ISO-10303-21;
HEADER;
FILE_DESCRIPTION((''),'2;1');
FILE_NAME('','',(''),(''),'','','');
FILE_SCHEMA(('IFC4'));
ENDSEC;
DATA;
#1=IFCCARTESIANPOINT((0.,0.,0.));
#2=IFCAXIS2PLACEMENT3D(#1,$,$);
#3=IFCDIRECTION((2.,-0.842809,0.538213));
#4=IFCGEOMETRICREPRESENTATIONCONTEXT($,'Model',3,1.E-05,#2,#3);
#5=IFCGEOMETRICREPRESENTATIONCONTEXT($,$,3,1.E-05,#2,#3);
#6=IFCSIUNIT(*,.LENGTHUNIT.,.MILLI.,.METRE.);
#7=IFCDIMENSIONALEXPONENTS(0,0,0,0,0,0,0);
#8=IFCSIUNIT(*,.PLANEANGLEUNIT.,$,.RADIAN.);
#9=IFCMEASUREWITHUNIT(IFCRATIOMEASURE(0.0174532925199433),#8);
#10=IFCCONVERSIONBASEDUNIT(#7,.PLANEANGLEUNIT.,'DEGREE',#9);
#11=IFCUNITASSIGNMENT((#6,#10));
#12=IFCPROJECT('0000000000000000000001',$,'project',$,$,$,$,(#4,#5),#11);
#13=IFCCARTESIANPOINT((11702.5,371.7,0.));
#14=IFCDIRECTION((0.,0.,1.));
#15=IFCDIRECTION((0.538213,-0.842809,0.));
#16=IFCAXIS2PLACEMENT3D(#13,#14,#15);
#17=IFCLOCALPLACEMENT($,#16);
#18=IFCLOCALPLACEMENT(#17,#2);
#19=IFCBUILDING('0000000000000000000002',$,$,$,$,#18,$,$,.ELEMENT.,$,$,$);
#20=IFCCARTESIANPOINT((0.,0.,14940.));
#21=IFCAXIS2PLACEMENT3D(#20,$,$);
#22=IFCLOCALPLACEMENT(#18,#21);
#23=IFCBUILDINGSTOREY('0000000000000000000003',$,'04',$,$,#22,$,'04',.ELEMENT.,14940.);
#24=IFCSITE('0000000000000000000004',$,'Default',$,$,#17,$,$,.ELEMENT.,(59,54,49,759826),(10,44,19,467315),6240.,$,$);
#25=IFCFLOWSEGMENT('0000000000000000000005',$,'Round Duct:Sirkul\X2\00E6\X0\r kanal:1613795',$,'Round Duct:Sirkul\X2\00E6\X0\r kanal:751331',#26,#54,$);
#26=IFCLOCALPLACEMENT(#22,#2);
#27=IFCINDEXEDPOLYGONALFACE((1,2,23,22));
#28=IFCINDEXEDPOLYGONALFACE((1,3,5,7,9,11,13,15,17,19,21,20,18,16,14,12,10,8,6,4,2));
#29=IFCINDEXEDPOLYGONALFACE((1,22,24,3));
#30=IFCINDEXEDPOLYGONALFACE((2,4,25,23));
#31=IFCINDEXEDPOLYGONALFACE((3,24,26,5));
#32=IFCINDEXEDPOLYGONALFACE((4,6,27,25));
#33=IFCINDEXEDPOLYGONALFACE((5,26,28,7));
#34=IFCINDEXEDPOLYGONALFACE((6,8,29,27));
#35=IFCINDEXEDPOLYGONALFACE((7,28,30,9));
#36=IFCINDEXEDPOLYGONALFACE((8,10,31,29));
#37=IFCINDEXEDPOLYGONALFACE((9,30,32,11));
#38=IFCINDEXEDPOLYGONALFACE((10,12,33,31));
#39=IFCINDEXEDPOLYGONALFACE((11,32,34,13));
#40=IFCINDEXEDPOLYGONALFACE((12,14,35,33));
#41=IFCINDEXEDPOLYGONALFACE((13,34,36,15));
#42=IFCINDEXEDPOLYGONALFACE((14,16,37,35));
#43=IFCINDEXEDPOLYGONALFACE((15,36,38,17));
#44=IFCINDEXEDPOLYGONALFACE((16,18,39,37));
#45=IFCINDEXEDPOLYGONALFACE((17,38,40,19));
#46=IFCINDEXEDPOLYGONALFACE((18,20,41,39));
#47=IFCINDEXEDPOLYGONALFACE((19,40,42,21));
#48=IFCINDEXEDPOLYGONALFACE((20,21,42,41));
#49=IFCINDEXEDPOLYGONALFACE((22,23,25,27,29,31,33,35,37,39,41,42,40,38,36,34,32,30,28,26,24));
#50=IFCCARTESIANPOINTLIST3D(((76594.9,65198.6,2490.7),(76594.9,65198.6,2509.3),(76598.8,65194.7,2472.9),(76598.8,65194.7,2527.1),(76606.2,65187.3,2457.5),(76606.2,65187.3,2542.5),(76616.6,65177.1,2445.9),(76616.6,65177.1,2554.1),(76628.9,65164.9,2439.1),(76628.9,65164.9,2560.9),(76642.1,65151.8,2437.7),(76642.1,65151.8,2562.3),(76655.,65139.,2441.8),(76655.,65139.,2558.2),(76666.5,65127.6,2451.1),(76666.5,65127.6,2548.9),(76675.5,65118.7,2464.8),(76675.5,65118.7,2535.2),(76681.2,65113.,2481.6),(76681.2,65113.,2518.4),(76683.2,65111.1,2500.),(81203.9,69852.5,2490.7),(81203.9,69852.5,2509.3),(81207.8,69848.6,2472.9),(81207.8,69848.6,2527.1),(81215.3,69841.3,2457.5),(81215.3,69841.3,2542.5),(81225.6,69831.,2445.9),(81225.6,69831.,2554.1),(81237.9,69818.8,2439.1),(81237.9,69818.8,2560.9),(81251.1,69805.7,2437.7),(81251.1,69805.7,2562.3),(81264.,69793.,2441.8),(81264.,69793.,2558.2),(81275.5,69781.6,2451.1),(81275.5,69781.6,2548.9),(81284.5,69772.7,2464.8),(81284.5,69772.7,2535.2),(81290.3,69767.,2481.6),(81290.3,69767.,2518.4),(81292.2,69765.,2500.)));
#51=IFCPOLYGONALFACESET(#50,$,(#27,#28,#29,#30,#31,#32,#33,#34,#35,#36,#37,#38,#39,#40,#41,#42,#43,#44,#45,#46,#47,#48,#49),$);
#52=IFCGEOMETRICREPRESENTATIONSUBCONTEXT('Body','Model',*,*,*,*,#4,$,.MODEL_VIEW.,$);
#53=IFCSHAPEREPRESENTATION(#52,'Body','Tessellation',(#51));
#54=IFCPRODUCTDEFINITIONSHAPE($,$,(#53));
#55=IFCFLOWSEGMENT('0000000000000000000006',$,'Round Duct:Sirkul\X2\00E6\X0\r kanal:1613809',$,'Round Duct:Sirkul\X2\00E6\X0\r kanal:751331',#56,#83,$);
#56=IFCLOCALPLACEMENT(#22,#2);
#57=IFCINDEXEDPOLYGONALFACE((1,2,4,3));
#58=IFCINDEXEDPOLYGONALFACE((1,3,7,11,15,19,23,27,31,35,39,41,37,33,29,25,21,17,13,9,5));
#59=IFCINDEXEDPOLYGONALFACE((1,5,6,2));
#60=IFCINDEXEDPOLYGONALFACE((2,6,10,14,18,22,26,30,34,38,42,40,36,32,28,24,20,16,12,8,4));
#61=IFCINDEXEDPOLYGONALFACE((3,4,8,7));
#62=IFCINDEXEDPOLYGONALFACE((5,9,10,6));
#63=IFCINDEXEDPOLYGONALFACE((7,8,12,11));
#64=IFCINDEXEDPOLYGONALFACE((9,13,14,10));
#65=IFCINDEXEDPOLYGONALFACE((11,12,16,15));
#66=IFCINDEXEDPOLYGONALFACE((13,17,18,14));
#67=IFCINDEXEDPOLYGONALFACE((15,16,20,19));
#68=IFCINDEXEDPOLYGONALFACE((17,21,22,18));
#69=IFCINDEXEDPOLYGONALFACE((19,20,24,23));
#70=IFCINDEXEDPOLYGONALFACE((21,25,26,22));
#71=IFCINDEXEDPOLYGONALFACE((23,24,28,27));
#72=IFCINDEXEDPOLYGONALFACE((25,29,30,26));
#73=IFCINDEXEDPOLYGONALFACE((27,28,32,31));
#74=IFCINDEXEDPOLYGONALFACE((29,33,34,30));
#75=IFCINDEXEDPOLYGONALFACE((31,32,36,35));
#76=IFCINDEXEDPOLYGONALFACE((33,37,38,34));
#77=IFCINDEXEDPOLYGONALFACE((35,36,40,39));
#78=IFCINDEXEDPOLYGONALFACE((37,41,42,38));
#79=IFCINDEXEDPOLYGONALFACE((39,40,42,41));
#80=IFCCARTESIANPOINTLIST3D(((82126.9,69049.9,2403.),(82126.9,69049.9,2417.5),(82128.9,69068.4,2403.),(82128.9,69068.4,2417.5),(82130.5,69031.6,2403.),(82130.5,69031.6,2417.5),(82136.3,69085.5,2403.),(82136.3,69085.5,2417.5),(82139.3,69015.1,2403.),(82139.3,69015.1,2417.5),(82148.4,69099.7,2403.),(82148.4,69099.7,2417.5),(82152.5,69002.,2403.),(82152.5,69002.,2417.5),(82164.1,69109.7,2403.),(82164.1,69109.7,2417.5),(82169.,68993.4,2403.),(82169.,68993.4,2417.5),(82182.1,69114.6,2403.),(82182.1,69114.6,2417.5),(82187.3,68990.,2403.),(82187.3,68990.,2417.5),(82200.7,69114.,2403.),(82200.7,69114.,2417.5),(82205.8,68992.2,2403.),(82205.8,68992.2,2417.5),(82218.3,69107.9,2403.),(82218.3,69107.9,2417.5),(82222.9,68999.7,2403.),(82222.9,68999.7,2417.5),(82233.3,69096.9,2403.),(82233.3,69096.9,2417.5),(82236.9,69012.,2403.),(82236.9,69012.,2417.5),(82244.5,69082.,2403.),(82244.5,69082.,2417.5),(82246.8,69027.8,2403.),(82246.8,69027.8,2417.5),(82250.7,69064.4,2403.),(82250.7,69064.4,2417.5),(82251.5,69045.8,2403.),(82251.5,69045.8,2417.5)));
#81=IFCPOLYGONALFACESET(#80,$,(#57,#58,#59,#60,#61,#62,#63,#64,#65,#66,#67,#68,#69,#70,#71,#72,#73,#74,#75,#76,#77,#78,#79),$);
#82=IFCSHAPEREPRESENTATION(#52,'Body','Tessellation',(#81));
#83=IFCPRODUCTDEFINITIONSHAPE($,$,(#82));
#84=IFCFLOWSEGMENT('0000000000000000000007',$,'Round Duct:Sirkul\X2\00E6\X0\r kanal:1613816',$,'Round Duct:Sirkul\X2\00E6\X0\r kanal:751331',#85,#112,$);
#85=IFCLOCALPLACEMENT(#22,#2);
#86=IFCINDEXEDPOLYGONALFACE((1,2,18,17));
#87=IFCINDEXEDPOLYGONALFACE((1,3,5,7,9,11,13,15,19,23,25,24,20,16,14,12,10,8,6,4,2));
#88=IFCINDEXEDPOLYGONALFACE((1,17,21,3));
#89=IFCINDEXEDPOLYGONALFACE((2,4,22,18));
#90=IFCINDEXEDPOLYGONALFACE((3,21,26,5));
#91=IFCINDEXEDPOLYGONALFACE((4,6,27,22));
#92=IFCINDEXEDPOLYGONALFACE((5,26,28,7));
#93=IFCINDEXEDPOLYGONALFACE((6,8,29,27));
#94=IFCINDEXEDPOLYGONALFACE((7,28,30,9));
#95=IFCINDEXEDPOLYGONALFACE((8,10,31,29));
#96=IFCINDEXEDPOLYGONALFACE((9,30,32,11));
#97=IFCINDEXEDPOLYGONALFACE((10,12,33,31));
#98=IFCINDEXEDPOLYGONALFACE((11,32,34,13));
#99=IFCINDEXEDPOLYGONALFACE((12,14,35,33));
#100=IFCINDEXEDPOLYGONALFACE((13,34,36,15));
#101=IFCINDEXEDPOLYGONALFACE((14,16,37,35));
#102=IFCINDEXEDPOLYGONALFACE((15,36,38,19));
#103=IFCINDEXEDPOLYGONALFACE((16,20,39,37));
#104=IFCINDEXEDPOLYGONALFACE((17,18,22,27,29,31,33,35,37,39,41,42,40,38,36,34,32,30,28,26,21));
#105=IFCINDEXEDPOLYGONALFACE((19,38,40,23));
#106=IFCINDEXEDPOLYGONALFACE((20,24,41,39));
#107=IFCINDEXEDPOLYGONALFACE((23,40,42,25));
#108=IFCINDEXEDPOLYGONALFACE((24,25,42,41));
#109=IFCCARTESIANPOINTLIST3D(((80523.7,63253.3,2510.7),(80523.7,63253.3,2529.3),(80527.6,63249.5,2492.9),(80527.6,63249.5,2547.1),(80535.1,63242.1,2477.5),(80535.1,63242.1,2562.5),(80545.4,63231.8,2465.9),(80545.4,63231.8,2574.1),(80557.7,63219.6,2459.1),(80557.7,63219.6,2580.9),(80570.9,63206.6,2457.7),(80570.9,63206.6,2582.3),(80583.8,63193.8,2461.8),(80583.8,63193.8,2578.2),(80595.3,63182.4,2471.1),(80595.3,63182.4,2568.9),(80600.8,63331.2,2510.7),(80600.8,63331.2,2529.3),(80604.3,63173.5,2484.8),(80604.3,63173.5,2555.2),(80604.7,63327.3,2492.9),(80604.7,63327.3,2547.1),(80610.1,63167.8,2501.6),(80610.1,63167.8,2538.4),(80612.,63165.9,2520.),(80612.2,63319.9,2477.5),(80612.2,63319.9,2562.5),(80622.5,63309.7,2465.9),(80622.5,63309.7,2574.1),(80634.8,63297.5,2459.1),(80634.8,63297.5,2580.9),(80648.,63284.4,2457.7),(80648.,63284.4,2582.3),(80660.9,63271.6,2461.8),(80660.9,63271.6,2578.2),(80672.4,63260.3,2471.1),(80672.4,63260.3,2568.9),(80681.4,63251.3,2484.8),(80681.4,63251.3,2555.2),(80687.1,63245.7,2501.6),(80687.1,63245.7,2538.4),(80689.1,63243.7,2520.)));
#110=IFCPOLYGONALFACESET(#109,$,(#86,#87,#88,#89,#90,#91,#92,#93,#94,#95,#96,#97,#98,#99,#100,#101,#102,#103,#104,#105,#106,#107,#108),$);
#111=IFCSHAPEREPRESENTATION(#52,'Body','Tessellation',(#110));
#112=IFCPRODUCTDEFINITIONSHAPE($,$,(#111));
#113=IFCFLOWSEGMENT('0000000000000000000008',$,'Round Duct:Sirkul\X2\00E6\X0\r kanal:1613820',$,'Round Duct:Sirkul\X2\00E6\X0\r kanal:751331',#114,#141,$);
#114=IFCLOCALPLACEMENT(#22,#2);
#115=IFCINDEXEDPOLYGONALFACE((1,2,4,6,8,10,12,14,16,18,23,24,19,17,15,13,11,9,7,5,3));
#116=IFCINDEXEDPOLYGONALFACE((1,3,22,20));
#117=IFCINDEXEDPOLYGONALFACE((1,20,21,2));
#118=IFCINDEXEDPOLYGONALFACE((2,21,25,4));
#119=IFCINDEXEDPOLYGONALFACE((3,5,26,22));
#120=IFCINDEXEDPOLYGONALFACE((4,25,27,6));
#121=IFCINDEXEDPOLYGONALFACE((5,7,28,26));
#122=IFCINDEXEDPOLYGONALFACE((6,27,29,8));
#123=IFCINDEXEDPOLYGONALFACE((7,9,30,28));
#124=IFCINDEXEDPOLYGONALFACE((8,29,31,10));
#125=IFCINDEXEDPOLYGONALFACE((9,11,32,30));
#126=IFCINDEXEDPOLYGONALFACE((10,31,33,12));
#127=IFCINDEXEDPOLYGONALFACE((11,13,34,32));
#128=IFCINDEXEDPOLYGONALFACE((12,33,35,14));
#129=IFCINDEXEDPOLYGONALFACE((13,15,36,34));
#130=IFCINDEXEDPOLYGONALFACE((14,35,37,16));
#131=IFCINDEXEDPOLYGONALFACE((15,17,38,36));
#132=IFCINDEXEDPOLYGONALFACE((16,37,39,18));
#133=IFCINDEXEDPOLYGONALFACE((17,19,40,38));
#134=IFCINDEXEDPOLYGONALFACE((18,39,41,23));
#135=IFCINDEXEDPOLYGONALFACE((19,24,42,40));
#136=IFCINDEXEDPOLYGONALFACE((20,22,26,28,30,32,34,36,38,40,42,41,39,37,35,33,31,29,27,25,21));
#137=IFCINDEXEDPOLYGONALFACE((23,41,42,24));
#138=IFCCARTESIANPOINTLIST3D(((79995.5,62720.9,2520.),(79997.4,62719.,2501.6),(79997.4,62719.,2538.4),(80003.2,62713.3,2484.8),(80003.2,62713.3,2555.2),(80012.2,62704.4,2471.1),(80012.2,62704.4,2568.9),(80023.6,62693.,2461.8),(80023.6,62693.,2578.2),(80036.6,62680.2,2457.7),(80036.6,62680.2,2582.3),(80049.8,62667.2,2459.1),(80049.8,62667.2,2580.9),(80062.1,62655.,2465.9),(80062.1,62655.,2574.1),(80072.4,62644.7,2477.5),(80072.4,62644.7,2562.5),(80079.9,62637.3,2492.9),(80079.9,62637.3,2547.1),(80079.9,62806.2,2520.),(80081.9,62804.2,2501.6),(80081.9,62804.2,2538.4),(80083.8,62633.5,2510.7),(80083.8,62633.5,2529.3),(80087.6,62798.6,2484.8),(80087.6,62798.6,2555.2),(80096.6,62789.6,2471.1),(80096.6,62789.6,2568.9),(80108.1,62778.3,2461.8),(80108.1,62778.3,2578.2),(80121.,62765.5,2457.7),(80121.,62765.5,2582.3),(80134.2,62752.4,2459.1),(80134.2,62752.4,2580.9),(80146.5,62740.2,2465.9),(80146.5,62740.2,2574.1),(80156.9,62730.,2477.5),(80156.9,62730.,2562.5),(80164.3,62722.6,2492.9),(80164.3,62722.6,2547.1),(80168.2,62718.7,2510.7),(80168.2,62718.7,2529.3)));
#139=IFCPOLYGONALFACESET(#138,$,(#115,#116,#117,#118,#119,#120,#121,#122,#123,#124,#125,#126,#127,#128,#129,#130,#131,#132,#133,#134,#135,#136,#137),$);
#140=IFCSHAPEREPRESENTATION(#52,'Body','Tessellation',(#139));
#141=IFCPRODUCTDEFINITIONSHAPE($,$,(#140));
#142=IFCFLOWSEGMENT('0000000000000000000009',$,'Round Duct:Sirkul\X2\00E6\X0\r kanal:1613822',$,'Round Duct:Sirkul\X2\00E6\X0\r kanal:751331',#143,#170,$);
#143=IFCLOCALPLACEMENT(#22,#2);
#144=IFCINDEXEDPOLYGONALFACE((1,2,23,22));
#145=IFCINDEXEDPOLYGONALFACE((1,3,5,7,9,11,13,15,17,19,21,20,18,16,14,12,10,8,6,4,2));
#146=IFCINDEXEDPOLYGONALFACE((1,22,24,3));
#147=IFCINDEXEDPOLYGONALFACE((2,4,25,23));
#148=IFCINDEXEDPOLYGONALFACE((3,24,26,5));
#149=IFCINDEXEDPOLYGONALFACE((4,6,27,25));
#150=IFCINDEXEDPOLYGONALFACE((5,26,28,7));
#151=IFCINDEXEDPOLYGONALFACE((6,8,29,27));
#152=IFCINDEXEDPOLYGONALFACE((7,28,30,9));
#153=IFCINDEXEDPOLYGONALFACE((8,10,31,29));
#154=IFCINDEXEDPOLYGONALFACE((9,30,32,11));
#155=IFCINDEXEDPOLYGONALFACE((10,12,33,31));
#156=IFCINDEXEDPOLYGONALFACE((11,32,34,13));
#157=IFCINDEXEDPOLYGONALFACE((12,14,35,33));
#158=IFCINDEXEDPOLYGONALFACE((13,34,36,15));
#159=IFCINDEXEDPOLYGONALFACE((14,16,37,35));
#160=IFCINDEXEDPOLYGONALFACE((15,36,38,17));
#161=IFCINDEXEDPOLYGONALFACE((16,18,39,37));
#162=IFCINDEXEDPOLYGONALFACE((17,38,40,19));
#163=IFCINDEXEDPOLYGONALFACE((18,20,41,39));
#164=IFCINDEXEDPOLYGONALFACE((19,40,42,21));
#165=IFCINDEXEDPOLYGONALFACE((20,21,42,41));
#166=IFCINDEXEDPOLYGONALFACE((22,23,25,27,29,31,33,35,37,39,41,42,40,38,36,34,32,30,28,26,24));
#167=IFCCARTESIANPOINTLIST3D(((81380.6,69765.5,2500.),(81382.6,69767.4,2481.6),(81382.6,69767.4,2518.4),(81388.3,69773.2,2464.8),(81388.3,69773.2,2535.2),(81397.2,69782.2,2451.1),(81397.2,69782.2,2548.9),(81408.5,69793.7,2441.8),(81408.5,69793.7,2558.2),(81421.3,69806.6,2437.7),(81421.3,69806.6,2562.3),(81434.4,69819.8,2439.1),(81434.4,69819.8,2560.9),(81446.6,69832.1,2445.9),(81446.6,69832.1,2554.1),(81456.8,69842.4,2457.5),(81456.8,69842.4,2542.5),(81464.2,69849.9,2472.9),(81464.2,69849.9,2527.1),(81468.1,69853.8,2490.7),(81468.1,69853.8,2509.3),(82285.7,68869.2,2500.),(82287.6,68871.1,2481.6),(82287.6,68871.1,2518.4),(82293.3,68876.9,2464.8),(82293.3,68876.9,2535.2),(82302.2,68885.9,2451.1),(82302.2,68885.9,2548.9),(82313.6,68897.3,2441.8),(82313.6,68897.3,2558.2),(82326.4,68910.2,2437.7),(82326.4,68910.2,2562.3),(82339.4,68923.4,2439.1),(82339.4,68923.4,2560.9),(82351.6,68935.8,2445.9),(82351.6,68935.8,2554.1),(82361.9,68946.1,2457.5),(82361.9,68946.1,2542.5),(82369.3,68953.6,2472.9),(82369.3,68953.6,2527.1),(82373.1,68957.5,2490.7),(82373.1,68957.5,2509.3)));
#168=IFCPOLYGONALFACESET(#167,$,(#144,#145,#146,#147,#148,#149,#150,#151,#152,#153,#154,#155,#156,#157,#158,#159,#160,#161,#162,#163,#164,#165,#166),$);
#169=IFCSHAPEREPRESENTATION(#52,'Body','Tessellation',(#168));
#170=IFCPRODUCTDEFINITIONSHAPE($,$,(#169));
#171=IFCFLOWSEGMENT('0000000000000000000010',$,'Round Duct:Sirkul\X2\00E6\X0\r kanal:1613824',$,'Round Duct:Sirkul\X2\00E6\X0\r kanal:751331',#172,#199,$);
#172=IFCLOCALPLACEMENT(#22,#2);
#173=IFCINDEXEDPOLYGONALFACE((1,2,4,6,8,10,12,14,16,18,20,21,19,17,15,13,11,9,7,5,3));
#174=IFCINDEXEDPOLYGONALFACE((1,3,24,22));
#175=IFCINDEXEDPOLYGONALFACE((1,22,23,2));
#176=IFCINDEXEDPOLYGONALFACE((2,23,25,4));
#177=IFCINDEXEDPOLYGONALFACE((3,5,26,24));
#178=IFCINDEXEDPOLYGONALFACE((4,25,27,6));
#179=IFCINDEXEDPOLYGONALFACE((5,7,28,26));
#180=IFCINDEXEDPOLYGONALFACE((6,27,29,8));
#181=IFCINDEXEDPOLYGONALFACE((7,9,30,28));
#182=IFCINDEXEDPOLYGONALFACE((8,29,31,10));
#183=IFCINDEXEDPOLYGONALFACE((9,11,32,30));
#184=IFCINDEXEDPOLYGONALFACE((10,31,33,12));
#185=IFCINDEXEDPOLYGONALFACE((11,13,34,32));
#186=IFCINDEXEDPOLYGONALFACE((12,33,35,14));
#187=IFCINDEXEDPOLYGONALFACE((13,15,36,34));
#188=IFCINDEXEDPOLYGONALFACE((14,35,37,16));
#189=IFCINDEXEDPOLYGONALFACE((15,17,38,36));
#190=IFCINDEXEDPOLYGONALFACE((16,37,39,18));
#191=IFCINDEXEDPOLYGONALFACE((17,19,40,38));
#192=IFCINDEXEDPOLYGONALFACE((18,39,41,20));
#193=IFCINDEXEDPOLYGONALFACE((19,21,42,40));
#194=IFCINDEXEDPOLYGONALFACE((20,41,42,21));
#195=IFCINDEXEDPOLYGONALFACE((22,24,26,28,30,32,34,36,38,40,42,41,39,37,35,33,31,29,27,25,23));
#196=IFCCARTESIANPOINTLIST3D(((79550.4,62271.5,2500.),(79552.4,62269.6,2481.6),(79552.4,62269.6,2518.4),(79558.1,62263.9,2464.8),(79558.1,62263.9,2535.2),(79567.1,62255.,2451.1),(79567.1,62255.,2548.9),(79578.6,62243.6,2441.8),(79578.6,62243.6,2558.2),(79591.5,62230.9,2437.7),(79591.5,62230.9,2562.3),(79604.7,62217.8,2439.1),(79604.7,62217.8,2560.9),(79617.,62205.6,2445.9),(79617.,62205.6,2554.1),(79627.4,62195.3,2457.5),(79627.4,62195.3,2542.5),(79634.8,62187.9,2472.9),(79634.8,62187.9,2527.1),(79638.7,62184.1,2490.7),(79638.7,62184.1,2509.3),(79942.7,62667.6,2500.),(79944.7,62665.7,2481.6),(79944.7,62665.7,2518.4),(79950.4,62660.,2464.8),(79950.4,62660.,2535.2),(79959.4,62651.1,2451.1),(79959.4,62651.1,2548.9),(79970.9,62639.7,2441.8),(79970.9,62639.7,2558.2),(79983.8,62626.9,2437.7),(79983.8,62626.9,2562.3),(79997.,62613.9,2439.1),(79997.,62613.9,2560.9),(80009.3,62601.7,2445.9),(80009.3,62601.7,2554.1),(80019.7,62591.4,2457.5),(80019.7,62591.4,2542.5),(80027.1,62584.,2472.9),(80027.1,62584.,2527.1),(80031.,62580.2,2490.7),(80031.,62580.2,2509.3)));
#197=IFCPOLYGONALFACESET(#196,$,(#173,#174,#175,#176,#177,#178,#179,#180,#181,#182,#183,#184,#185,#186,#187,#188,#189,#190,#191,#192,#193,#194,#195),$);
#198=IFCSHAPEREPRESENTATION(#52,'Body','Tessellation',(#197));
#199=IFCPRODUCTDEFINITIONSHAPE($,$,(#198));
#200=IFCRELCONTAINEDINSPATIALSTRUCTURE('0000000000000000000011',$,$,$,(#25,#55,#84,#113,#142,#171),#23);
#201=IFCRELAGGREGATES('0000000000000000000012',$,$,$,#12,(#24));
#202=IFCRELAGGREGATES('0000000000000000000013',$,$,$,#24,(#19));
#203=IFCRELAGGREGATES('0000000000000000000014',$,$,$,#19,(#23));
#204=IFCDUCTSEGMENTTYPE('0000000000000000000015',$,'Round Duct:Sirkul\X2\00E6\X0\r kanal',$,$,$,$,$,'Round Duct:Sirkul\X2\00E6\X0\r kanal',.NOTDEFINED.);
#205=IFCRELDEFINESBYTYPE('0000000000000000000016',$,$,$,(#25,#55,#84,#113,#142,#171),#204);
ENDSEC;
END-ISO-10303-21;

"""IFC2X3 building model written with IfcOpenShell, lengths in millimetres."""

from ifc_helpers import new_model, entity, si_unit, converted_unit, direction, frame, frame_2d, origin, origin_2d_with_axis, place, context, subcontext, project, spatial, circle, extrude, type_object, element, save


model = new_model("IFC2X3")

# Units and contexts
model_context = context("Model", 3, precision=1e-05, world=origin(), true_north=direction((2.0, -0.842809, 0.538213)))
context_of_model = context(None, 3, precision=1e-05, world=origin(), true_north=direction((2.0, -0.842809, 0.538213)))
body_context = subcontext(model_context, "Body", "Model", "MODEL_VIEW")
ifc_project = project(units=[si_unit("LENGTHUNIT", "METRE", prefix="MILLI"), converted_unit("PLANEANGLEUNIT", "DEGREE", entity("IfcRatioMeasure", 0.0174532925199433), si_unit("PLANEANGLEUNIT", "RADIAN"), dimensions=[0, 0, 0, 0, 0, 0, 0])], contexts=[model_context, context_of_model])

# Site, building, storey
site_placement = place(None, frame((11702.5, 371.7, 0.0), z_axis=(0.0, 0.0, 1.0), x_axis=(0.538213, -0.842809, 0.0)))
site = spatial("IfcSite", under=ifc_project, at=site_placement, Name="Default", CompositionType="ELEMENT", RefLatitude=(59, 54, 49, 759826), RefLongitude=(10, 44, 19, 467315), RefElevation=6240.0)
building_placement = place(site_placement, origin())
building = spatial("IfcBuilding", under=site, at=building_placement, CompositionType="ELEMENT")
storey_placement = place(building_placement, frame((0.0, 0.0, 14940.0)))
storey = spatial("IfcBuildingStorey", under=building, at=storey_placement, Name="04", LongName="04", CompositionType="ELEMENT", Elevation=14940.0)

# Flow segments
duct_segment_type = type_object("IfcDuctSegmentType", Name="Round Duct:Sirkulær kanal", ElementType="Round Duct:Sirkulær kanal", PredefinedType="NOTDEFINED")
flow_segment_1_placement = place(storey_placement, origin())
element("IfcFlowSegment", 1, at=flow_segment_1_placement, inside=storey, type_object=duct_segment_type, Name="Round Duct:Sirkulær kanal:1613795", ObjectType="Round Duct:Sirkulær kanal:751331", context=body_context, shape_type="SweptSolid", body=[
    extrude(circle(Radius=62.5, at=origin_2d_with_axis()), frame((76638.8, 65155.1, 2500.0), z_axis=(0.703669, 0.710528, 0.0), x_axis=(0.710528, -0.703669, 0.0)), (0.0, 0.0, 1.0), 6550.0),
])
flow_segment_2_placement = place(storey_placement, origin())
element("IfcFlowSegment", 2, at=flow_segment_2_placement, inside=storey, type_object=duct_segment_type, Name="Round Duct:Sirkulær kanal:1613809", ObjectType="Round Duct:Sirkulær kanal:751331", context=body_context, shape_type="SweptSolid", body=[
    extrude(circle(Radius=62.5, at=frame_2d((0.0, 0.0), x_axis=(1.0, 0.0))), frame((82189.4, 69052.5, 2403.0), z_axis=(0.0, 0.0, 1.0), x_axis=(0.703669, 0.710528, 0.0)), (0.0, 0.0, 1.0), 14.5),
])
flow_segment_3_placement = place(storey_placement, origin())
element("IfcFlowSegment", 3, at=flow_segment_3_placement, inside=storey, type_object=duct_segment_type, Name="Round Duct:Sirkulær kanal:1613816", ObjectType="Round Duct:Sirkulær kanal:751331", context=body_context, shape_type="SweptSolid", body=[
    extrude(circle(Radius=62.5, at=frame_2d((0.0, 0.0), x_axis=(1.0, 0.0))), frame((80567.6, 63209.8, 2520.0), z_axis=(0.703669, 0.710528, 0.0), x_axis=(0.710528, -0.703669, 0.0)), (0.0, 0.0, 1.0), 109.6),
])
flow_segment_4_placement = place(storey_placement, origin())
element("IfcFlowSegment", 4, at=flow_segment_4_placement, inside=storey, type_object=duct_segment_type, Name="Round Duct:Sirkulær kanal:1613820", ObjectType="Round Duct:Sirkulær kanal:751331", context=body_context, shape_type="SweptSolid", body=[
    extrude(circle(Radius=62.5, at=origin_2d_with_axis()), frame((80039.9, 62677.0, 2520.0), z_axis=(0.703669, 0.710528, 0.0), x_axis=(-0.710528, 0.703669, 0.0)), (0.0, 0.0, 1.0), 120.0),
])
flow_segment_5_placement = place(storey_placement, origin())
element("IfcFlowSegment", 5, at=flow_segment_5_placement, inside=storey, type_object=duct_segment_type, Name="Round Duct:Sirkulær kanal:1613822", ObjectType="Round Duct:Sirkulær kanal:751331", context=body_context, shape_type="SweptSolid", body=[
    extrude(circle(Radius=62.5, at=origin_2d_with_axis()), frame((81424.6, 69809.9, 2500.0), z_axis=(0.710528, -0.703669, 0.0), x_axis=(-0.703669, -0.710528, 0.0)), (0.0, 0.0, 1.0), 1273.8),
])
flow_segment_6_placement = place(storey_placement, origin())
element("IfcFlowSegment", 6, at=flow_segment_6_placement, inside=storey, type_object=duct_segment_type, Name="Round Duct:Sirkulær kanal:1613824", ObjectType="Round Duct:Sirkulær kanal:751331", context=body_context, shape_type="SweptSolid", body=[
    extrude(circle(Radius=62.5, at=origin_2d_with_axis()), frame((79594.8, 62227.6, 2500.0), z_axis=(0.703669, 0.710528, 0.0), x_axis=(-0.710528, 0.703669, 0.0)), (0.0, 0.0, 1.0), 557.5),
])

save(model, "model.ifc")
